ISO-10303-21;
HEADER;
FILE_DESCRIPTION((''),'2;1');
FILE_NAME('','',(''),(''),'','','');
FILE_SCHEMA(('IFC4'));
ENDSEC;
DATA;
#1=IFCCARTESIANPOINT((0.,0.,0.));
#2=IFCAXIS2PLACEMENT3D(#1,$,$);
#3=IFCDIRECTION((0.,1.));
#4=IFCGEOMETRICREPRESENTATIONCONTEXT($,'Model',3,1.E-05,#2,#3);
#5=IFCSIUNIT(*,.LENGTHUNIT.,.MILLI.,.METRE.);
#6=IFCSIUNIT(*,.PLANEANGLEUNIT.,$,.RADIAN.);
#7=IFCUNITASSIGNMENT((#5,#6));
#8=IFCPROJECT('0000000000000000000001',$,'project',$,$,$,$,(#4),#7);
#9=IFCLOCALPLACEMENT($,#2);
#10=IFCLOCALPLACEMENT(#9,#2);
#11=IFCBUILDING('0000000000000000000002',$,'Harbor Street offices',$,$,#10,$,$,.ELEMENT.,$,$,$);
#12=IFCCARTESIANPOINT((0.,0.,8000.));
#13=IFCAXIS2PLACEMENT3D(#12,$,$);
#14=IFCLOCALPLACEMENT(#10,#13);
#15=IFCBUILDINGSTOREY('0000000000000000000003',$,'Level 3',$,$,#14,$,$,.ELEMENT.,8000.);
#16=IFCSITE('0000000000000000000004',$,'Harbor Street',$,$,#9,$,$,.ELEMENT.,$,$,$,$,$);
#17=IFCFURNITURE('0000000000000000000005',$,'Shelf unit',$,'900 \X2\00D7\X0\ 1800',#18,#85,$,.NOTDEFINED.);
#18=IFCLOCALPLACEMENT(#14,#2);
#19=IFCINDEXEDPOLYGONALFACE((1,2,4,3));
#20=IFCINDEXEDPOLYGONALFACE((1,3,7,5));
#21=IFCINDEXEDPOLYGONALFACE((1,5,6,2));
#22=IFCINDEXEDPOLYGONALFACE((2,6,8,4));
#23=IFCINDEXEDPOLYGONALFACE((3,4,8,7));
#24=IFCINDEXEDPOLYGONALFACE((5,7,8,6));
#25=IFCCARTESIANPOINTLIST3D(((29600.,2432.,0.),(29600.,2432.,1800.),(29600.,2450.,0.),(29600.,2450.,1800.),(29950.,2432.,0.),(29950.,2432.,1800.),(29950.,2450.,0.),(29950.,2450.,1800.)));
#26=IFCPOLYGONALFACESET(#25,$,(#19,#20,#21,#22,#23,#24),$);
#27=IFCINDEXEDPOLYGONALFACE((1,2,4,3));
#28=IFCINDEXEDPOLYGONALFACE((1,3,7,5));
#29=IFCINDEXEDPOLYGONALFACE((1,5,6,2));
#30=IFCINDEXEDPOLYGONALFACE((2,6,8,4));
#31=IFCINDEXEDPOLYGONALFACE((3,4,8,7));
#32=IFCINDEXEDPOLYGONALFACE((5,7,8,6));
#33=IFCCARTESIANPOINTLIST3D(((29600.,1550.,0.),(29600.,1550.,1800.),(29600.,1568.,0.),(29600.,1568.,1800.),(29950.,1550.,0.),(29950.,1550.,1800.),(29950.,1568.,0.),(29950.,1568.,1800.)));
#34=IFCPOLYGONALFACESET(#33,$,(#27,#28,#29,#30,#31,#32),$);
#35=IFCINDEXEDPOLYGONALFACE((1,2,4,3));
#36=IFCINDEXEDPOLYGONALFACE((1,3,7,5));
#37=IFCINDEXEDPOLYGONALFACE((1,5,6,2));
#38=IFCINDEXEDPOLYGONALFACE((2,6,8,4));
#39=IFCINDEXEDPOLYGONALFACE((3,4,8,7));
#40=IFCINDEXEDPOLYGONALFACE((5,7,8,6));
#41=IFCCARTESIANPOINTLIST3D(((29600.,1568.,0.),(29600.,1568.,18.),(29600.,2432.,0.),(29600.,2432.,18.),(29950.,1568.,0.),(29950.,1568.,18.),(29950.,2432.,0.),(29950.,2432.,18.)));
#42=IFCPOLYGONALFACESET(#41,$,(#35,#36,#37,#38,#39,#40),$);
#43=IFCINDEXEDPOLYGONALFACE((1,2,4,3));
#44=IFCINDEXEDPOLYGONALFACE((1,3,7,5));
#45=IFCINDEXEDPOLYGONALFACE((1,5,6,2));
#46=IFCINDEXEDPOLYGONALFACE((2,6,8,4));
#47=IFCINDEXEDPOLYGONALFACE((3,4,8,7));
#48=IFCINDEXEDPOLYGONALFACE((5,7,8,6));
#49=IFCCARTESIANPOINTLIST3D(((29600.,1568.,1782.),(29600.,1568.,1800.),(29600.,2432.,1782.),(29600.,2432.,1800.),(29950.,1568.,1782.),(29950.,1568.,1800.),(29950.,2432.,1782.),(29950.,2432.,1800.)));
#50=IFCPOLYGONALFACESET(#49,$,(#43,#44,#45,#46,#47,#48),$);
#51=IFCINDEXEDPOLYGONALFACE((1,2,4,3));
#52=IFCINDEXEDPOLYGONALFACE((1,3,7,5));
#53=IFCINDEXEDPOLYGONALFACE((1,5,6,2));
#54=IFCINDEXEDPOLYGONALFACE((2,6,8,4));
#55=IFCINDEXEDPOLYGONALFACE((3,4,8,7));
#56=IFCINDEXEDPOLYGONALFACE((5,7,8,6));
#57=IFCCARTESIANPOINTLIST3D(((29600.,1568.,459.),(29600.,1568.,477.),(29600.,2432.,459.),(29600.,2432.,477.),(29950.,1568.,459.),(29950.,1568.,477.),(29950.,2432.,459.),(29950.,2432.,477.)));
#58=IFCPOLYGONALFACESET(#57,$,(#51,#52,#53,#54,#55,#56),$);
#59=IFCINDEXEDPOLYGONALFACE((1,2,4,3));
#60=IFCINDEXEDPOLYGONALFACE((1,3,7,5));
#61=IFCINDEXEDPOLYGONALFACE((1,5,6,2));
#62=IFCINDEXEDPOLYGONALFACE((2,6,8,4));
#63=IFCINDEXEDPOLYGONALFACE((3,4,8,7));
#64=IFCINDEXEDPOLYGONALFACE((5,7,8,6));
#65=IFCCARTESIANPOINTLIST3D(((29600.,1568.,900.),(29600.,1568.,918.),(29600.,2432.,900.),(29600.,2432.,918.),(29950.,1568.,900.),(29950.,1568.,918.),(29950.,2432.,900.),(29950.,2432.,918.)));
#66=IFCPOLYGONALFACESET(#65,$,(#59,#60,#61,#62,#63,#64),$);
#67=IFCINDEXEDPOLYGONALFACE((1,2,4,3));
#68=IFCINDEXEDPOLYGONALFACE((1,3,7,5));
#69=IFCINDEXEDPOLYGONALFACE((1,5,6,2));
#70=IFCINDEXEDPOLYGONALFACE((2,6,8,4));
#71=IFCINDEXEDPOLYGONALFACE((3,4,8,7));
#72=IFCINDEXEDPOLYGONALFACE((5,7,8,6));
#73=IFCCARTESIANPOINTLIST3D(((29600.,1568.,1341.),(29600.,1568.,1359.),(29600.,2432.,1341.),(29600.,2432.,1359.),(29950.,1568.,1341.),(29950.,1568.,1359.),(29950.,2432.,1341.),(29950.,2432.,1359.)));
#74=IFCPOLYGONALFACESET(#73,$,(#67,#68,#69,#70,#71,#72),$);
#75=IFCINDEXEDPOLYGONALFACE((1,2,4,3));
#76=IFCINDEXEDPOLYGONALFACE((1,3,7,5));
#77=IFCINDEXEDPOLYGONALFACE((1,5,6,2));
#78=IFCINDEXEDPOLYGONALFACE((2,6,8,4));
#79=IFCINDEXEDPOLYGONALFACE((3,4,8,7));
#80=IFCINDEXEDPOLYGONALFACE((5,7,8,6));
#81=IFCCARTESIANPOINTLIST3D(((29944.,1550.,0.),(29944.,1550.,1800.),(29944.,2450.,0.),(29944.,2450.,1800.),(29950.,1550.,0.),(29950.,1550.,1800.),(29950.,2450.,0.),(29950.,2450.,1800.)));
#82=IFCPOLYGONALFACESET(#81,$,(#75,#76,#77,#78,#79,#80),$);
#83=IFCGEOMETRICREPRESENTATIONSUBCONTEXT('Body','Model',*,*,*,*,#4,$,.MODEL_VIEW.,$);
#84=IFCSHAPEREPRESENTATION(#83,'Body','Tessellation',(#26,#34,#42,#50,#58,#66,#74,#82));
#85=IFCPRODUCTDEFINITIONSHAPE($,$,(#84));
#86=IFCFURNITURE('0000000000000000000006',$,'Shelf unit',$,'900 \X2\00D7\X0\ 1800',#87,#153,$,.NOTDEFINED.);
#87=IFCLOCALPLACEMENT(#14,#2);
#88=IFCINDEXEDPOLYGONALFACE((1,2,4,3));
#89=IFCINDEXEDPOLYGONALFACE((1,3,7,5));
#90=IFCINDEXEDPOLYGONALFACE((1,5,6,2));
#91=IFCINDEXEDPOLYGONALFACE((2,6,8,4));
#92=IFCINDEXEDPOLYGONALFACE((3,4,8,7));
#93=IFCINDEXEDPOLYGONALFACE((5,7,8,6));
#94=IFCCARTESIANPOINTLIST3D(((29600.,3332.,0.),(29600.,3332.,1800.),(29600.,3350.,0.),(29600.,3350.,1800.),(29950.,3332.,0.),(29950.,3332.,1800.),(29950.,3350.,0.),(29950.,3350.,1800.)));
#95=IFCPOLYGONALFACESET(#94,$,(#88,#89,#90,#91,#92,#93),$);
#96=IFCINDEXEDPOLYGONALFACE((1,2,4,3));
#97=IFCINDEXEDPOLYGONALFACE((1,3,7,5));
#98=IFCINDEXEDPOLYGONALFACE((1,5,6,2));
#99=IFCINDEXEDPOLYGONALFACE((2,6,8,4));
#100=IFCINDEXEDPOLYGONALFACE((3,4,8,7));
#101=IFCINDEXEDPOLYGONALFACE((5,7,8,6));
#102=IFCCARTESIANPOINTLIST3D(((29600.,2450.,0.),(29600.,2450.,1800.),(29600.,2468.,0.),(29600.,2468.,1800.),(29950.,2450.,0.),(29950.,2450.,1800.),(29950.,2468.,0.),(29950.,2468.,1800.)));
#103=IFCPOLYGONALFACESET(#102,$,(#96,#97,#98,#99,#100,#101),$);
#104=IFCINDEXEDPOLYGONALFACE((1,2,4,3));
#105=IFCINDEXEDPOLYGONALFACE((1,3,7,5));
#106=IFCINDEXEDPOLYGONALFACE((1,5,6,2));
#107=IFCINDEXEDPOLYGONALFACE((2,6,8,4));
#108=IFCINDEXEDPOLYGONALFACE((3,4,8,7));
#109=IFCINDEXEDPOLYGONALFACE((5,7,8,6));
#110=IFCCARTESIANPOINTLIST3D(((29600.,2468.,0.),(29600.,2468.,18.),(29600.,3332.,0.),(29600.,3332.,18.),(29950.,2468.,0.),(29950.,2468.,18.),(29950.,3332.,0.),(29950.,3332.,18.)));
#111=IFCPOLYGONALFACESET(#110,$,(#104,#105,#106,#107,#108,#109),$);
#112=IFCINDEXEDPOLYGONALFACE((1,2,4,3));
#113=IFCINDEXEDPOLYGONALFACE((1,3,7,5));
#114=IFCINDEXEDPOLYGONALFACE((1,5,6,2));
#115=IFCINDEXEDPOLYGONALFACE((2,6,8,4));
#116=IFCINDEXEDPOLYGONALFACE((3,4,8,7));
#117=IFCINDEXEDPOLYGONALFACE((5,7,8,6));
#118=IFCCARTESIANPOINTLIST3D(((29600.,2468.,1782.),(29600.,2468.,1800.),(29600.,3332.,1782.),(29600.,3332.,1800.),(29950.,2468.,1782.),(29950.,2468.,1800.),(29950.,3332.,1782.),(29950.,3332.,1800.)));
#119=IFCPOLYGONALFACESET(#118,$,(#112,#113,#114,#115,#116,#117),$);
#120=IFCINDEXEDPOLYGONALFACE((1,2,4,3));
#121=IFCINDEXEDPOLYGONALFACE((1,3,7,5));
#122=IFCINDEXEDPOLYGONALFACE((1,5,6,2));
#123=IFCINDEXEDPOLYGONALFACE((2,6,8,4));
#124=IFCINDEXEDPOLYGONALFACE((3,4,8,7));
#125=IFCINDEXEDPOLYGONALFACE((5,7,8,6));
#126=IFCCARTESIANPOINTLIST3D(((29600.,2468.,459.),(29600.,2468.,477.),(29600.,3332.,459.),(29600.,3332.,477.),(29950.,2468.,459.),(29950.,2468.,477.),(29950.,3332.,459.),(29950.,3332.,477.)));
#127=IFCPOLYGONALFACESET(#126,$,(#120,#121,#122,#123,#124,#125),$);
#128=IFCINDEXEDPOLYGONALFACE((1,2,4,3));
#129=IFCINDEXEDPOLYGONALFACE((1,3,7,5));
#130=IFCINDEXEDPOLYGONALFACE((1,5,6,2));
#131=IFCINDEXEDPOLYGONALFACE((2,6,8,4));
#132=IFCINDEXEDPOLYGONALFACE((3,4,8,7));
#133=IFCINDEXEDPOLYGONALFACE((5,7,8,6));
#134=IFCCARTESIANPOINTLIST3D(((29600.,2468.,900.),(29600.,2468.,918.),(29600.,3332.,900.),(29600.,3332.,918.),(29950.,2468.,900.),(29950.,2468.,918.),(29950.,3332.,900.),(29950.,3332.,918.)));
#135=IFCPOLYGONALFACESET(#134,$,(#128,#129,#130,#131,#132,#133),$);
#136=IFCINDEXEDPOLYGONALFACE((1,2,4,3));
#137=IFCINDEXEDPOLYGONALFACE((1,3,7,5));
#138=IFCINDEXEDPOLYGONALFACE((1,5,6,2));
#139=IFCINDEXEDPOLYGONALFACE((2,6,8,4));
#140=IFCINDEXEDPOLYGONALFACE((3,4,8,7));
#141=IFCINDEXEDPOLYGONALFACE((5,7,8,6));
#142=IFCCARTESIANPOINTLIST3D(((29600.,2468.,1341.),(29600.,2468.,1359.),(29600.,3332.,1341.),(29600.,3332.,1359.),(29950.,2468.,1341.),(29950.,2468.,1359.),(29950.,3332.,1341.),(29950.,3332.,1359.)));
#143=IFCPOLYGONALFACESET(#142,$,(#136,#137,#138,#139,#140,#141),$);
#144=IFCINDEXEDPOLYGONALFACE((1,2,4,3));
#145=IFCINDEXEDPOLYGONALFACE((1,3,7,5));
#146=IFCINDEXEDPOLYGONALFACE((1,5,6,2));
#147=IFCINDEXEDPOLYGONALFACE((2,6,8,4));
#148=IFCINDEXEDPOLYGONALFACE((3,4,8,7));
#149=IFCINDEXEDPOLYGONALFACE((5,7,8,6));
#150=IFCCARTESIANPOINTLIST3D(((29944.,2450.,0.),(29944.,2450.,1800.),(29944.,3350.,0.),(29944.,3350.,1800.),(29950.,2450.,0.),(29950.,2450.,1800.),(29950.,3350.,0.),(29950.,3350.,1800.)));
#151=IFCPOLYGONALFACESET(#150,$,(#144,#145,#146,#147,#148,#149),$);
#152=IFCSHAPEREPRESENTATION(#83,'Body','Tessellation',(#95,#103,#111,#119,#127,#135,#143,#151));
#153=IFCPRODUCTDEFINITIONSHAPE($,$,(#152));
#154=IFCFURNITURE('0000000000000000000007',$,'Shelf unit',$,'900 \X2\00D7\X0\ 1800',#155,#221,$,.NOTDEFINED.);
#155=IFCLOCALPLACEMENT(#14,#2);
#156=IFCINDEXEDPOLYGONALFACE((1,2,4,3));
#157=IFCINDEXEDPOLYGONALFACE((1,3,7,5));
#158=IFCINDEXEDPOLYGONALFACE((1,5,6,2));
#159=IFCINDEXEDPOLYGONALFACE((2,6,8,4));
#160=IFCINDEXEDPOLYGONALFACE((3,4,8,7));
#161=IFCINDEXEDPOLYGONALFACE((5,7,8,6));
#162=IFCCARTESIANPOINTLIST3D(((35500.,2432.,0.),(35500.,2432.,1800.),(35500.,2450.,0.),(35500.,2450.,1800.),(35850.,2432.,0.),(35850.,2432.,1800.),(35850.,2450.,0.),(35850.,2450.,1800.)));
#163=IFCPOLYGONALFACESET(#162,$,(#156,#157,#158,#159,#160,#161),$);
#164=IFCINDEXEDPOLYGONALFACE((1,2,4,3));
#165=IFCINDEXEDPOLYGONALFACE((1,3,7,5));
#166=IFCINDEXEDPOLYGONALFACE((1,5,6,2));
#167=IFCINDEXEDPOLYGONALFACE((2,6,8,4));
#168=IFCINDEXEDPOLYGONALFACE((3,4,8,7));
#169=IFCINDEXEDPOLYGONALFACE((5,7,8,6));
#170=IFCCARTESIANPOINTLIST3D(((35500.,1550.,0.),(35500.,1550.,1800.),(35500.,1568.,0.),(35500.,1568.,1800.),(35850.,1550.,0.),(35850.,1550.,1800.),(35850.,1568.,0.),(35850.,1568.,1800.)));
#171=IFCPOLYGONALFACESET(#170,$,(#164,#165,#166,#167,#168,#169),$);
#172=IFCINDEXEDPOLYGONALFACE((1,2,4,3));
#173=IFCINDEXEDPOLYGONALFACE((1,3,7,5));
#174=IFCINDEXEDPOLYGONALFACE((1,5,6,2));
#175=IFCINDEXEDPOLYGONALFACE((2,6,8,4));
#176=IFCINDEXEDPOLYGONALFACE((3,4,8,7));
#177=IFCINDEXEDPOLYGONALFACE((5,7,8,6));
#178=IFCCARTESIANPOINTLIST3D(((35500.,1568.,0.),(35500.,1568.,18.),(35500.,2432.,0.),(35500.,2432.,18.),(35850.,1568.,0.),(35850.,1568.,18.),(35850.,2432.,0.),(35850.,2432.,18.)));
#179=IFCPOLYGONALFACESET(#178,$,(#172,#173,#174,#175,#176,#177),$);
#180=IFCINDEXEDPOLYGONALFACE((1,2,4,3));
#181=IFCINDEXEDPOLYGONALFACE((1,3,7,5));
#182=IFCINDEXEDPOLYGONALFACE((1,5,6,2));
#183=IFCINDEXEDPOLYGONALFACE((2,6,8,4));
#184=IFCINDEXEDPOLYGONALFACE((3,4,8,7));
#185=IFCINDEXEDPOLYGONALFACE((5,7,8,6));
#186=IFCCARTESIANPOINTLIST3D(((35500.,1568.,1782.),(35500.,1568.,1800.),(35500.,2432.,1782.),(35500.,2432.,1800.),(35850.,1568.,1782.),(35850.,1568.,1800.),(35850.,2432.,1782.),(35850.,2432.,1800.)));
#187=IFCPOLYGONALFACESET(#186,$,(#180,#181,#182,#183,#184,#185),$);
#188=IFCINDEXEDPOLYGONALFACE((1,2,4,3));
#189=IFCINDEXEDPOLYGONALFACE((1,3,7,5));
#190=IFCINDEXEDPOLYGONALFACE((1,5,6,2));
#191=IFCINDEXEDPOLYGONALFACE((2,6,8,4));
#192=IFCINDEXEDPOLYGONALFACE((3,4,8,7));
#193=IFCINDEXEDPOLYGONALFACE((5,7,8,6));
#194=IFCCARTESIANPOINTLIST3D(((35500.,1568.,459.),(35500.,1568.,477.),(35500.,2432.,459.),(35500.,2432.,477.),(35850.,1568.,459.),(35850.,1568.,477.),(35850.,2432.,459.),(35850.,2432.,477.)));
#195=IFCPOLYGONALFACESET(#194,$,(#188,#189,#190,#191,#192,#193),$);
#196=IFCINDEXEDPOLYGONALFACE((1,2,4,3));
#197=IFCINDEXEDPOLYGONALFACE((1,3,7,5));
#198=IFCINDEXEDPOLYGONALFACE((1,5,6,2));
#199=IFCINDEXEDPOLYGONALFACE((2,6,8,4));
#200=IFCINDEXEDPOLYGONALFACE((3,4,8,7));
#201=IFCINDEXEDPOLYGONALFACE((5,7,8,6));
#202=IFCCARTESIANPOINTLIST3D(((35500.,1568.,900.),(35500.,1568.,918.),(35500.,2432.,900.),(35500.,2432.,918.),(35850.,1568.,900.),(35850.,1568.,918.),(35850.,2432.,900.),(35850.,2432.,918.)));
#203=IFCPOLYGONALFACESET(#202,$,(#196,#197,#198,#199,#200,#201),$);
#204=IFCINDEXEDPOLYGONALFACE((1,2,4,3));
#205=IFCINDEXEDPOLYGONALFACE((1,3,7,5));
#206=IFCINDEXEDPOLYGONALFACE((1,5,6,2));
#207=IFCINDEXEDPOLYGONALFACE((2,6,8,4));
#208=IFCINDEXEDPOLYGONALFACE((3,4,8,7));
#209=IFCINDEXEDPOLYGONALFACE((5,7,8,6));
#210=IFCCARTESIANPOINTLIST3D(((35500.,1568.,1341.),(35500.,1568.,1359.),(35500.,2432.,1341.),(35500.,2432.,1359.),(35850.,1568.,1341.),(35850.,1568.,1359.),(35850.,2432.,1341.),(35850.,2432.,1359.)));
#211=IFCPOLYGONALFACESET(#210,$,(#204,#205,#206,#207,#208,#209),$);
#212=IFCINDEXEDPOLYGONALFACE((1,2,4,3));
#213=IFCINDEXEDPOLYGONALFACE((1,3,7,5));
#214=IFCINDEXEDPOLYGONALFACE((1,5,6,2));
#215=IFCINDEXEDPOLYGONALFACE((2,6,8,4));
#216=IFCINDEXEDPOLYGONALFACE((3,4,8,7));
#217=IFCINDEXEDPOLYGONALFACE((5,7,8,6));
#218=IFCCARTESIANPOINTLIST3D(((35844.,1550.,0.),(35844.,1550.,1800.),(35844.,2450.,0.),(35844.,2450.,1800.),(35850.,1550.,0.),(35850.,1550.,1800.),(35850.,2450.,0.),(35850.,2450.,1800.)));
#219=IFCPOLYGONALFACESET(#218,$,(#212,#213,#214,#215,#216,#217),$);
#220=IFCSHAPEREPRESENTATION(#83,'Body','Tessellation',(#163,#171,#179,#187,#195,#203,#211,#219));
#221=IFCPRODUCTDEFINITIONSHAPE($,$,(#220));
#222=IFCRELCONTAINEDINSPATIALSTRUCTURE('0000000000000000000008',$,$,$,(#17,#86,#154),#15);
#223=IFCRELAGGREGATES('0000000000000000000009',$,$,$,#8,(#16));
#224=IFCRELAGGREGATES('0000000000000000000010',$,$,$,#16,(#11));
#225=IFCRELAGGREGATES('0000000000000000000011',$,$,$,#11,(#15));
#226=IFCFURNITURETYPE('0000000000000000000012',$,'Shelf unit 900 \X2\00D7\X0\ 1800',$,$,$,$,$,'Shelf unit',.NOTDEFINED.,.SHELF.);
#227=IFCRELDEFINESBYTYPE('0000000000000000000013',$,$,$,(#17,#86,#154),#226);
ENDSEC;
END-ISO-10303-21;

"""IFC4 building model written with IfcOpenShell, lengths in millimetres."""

from ifc_helpers import new_model, si_unit, direction, frame, origin, place, context, subcontext, project, spatial, polyline, outline, extrude, source, transform, mapped, type_object, type_shapes, element, save


model = new_model("IFC4")

# Units and contexts
model_context = context("Model", 3, precision=1e-05, world=origin(), true_north=direction((0.0, 1.0)))
body_context = subcontext(model_context, "Body", "Model", "MODEL_VIEW")
ifc_project = project(units=[si_unit("LENGTHUNIT", "METRE", prefix="MILLI"), si_unit("PLANEANGLEUNIT", "RADIAN")], contexts=[model_context])

# Site, building, storey
site_placement = place(None, origin())
site = spatial("IfcSite", under=ifc_project, at=site_placement, Name="Harbor Street", CompositionType="ELEMENT")
building_placement = place(site_placement, origin())
building = spatial("IfcBuilding", under=site, at=building_placement, Name="Harbor Street offices", CompositionType="ELEMENT")
storey_placement = place(building_placement, frame((0.0, 0.0, 8000.0)))
storey = spatial("IfcBuildingStorey", under=building, at=storey_placement, Name="Level 3", CompositionType="ELEMENT", Elevation=8000.0)

# Furniture
furniture_type_1 = type_object("IfcFurnitureType", Name="Shelf unit 900 × 1800", ElementType="Shelf unit", AssemblyPlace="NOTDEFINED", PredefinedType="SHELF")
shared_shape_1 = source(origin(), body_context, "Body", "SweptSolid", [
    extrude(outline(polyline([(-450.0, 0.0), (-432.0, 0.0), (-432.0, 350.0), (-450.0, 350.0), (-450.0, 0.0)])), origin(), (0.0, 0.0, 1.0), 1800.0),
    extrude(outline(polyline([(432.0, 0.0), (450.0, 0.0), (450.0, 350.0), (432.0, 350.0), (432.0, 0.0)])), origin(), (0.0, 0.0, 1.0), 1800.0),
    extrude(outline(polyline([(-432.0, 0.0), (432.0, 0.0), (432.0, 350.0), (-432.0, 350.0), (-432.0, 0.0)])), origin(), (0.0, 0.0, 1.0), 18.0),
    extrude(outline(polyline([(-432.0, 0.0), (432.0, 0.0), (432.0, 350.0), (-432.0, 350.0), (-432.0, 0.0)])), frame((0.0, 0.0, 1782.0)), (0.0, 0.0, 1.0), 18.0),
    extrude(outline(polyline([(-432.0, 0.0), (432.0, 0.0), (432.0, 350.0), (-432.0, 350.0), (-432.0, 0.0)])), frame((0.0, 0.0, 459.0)), (0.0, 0.0, 1.0), 18.0),
    extrude(outline(polyline([(-432.0, 0.0), (432.0, 0.0), (432.0, 350.0), (-432.0, 350.0), (-432.0, 0.0)])), frame((0.0, 0.0, 900.0)), (0.0, 0.0, 1.0), 18.0),
    extrude(outline(polyline([(-432.0, 0.0), (432.0, 0.0), (432.0, 350.0), (-432.0, 350.0), (-432.0, 0.0)])), frame((0.0, 0.0, 1341.0)), (0.0, 0.0, 1.0), 18.0),
    extrude(outline(polyline([(-450.0, 344.0), (450.0, 344.0), (450.0, 350.0), (-450.0, 350.0), (-450.0, 344.0)])), origin(), (0.0, 0.0, 1.0), 1800.0),
])
type_shapes(furniture_type_1, [shared_shape_1])
for number, where, z_axis, x_axis, name in (
    (1, (29600.0, 2000.0, 0.0), (0.0, 0.0, 1.0), (0.0, -1.0, 0.0), "Shelf unit"),
    (2, (29600.0, 2900.0, 0.0), (0.0, 0.0, 1.0), (0.0, -1.0, 0.0), "Shelf unit"),
    (3, (35500.0, 2000.0, 0.0), (0.0, 0.0, 1.0), (0.0, -1.0, 0.0), "Shelf unit"),
):
    element("IfcFurniture", number, at=place(storey_placement, frame(where, z_axis=z_axis, x_axis=x_axis)), inside=storey, type_object=furniture_type_1, Name=name, ObjectType="900 × 1800", PredefinedType="NOTDEFINED", context=body_context, shape_type="MappedRepresentation", body=[
        mapped(shared_shape_1, transform((0.0, 0.0, 0.0))),
    ])

save(model, "model.ifc")
